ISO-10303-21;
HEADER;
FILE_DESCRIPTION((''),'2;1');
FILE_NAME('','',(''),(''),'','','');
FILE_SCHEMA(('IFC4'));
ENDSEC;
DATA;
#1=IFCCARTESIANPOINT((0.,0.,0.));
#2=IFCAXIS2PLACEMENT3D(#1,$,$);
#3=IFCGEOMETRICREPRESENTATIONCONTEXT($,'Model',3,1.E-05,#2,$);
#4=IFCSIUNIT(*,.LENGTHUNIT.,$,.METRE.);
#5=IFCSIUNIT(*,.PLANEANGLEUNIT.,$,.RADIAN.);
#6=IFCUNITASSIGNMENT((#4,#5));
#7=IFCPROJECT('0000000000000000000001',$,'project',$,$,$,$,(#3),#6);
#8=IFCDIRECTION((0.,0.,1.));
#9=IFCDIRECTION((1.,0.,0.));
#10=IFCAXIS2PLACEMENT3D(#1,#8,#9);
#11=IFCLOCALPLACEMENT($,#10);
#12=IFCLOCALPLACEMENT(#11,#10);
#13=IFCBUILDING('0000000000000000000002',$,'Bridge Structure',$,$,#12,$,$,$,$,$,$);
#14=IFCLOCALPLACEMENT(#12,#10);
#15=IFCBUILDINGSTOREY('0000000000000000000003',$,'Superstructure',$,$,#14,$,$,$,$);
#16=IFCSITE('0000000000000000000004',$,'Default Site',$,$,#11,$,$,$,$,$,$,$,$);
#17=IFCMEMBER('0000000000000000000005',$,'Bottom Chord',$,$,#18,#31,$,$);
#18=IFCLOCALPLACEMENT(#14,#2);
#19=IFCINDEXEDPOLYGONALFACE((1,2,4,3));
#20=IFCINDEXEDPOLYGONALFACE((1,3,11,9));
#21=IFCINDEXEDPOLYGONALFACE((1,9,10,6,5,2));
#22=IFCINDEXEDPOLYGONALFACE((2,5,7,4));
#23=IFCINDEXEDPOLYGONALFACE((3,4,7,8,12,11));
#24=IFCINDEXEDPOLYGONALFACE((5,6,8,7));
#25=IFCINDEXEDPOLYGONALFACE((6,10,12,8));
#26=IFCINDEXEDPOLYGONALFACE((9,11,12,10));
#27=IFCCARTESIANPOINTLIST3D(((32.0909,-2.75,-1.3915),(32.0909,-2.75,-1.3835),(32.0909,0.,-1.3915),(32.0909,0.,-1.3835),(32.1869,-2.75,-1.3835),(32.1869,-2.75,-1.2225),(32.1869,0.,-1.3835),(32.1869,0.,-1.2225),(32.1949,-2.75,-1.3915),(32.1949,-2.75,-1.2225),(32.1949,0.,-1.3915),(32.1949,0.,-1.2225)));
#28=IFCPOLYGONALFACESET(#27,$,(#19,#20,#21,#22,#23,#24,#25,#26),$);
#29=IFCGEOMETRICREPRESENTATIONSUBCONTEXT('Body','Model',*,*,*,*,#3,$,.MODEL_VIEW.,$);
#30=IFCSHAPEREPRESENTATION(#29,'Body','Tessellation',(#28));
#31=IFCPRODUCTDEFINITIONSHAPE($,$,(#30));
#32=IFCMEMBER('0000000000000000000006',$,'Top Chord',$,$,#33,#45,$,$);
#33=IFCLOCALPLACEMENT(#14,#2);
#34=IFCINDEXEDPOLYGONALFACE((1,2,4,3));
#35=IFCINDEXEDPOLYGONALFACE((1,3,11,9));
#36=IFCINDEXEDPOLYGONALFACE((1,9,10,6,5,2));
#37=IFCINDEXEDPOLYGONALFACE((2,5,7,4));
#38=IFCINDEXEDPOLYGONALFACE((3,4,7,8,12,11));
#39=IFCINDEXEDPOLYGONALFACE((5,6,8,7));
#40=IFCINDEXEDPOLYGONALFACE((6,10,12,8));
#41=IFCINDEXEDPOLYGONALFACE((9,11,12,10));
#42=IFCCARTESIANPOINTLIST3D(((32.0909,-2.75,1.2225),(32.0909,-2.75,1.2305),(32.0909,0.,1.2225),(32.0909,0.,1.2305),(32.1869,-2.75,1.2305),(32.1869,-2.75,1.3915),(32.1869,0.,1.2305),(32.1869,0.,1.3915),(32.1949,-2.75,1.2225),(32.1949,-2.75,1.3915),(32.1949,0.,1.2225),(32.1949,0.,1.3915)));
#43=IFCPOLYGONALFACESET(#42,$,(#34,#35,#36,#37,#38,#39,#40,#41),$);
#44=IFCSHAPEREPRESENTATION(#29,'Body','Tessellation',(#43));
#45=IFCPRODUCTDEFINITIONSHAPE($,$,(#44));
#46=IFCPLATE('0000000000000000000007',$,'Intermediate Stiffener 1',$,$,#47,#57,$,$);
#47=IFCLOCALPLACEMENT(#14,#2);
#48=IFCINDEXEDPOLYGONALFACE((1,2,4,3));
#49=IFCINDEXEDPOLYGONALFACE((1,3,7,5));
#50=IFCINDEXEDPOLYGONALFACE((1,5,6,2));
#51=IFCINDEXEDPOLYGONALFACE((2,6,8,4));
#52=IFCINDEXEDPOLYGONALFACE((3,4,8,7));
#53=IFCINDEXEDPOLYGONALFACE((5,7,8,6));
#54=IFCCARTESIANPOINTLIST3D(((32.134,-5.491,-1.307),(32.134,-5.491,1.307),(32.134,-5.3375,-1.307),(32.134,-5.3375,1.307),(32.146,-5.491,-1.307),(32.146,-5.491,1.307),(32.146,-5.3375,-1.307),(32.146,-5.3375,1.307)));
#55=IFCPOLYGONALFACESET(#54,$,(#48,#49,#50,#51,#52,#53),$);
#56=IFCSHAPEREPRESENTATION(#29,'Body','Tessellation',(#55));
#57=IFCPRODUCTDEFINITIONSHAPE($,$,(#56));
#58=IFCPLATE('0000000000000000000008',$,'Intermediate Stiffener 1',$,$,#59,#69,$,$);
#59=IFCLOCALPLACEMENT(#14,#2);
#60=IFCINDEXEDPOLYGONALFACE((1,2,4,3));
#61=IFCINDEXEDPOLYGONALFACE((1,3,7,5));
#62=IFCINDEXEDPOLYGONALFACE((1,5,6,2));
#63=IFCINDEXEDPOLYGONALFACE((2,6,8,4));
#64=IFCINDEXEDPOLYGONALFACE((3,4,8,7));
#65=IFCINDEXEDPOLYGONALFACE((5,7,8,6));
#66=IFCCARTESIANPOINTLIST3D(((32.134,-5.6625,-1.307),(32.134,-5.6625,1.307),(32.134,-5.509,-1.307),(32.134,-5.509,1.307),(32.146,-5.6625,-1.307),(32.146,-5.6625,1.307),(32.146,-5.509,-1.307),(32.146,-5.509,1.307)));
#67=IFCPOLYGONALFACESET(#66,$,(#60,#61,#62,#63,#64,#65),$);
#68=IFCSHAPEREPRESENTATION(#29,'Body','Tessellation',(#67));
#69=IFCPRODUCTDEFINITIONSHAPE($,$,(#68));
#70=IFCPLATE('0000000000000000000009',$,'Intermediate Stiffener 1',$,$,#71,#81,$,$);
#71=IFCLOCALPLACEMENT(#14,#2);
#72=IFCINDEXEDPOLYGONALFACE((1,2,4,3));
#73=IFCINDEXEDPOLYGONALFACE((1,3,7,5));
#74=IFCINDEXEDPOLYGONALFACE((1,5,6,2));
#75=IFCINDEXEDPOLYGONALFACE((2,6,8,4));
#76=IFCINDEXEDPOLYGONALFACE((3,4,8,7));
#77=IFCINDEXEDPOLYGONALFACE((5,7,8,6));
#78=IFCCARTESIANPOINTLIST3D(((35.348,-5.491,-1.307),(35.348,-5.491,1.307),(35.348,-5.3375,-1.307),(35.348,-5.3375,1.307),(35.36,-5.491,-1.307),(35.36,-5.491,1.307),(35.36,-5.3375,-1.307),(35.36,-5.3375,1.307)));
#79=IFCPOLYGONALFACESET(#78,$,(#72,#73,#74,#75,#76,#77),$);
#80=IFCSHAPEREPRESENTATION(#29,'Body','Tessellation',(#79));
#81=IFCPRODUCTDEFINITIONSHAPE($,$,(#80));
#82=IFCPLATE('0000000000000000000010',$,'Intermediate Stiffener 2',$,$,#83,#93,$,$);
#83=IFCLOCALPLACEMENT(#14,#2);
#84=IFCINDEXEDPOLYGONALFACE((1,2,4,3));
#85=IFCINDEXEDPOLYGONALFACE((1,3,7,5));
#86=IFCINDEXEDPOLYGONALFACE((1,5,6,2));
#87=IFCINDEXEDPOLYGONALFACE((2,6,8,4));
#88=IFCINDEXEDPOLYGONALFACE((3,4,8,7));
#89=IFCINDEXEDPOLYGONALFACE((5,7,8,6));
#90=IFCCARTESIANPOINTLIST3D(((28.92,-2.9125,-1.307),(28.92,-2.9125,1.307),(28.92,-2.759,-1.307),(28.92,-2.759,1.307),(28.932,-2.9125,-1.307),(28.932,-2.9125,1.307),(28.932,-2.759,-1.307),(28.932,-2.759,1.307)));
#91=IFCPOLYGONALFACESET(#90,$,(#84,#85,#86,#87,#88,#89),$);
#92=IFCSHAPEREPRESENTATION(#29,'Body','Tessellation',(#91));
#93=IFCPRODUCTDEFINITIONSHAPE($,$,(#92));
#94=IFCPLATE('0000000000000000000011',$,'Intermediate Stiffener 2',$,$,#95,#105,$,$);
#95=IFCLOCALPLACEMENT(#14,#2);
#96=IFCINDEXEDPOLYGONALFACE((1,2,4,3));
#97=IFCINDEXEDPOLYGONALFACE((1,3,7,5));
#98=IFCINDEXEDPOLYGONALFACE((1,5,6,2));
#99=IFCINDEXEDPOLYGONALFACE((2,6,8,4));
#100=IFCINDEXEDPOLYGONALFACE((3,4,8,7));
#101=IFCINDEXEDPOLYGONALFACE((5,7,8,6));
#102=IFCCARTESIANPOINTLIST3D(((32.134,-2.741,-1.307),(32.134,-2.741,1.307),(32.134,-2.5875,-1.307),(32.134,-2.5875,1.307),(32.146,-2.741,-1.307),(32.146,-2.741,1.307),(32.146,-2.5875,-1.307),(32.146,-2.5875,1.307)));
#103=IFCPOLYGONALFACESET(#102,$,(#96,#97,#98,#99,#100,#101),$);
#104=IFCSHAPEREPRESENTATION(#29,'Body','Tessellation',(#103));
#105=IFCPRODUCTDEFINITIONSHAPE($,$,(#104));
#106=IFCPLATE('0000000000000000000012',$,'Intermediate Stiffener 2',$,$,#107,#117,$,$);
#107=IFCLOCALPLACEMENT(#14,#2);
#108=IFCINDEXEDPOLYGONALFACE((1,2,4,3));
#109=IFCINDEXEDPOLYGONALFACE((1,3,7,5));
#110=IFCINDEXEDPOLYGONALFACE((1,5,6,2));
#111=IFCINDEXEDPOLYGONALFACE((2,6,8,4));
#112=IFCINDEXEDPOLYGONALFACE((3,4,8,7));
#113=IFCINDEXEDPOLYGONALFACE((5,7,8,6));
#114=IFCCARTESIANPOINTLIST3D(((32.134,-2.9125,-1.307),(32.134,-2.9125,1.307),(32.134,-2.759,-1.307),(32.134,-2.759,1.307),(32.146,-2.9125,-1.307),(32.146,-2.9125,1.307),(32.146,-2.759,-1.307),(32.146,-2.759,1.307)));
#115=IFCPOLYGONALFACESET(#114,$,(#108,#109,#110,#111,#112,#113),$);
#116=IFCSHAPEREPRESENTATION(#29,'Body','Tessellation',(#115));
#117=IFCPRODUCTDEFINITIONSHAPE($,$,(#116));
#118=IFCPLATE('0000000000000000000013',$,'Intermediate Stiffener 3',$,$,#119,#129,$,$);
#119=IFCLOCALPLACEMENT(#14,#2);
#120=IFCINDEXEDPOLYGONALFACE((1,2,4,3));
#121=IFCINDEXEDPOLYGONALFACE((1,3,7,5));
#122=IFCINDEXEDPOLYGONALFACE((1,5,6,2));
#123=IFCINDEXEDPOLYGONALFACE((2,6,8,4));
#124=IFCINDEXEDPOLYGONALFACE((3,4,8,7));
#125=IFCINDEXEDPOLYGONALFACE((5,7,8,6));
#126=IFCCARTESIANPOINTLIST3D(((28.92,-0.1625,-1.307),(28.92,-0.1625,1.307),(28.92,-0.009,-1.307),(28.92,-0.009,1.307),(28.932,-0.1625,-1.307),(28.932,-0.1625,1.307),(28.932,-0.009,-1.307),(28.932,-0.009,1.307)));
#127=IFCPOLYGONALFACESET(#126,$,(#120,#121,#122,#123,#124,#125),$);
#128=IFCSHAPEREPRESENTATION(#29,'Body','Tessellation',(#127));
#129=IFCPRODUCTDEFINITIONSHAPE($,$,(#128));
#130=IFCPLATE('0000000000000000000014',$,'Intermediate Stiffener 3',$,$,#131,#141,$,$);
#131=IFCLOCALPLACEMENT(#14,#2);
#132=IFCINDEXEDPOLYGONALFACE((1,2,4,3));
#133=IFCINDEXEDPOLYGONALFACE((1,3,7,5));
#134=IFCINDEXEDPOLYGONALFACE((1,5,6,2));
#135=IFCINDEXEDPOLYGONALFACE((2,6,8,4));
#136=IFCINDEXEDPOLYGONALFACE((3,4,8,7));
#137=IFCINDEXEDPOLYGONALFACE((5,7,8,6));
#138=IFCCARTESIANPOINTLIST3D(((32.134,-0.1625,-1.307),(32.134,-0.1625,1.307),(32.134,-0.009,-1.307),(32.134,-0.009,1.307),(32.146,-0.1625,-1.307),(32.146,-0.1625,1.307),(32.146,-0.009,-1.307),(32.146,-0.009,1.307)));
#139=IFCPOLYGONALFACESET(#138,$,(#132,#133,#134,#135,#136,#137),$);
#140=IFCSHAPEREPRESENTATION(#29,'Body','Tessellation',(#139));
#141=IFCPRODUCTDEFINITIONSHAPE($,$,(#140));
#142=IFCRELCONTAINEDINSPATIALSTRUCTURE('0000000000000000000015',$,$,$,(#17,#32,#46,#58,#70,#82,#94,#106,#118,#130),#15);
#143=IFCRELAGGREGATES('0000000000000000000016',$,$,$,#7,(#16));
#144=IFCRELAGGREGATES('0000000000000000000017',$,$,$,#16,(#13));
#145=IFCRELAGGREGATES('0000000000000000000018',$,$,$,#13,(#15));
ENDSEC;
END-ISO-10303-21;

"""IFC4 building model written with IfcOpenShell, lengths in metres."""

from ifc_helpers import new_model, si_unit, frame, origin, origin_with_axes, origin_2d_with_axis, place, context, subcontext, project, spatial, rectangle, l_section, extrude, element, save


model = new_model("IFC4")

# Units and contexts
model_context = context("Model", 3, precision=1e-05, world=origin())
body_context = subcontext(model_context, "Body", "Model", "MODEL_VIEW")
ifc_project = project(units=[si_unit("LENGTHUNIT", "METRE"), si_unit("PLANEANGLEUNIT", "RADIAN")], contexts=[model_context])

# Site, building, storey
site_placement = place(None, origin_with_axes())
site = spatial("IfcSite", under=ifc_project, at=site_placement, Name="Default Site")
building_placement = place(site_placement, origin_with_axes())
building = spatial("IfcBuilding", under=site, at=building_placement, Name="Bridge Structure")
storey_placement = place(building_placement, origin_with_axes())
storey = spatial("IfcBuildingStorey", under=building, at=storey_placement, Name="Superstructure")

# Members
for number, where, z_axis, x_axis, name in (
    (1, (32.1429, -2.75, -1.307), (0.0, 1.0, 0.0), (-1.0, 0.0, 0.0), "Bottom Chord"),
    (2, (32.1429, -2.75, 1.307), (0.0, 1.0, 0.0), (-1.0, 0.0, 0.0), "Top Chord"),
):
    element("IfcMember", number, at=place(storey_placement, frame(where, z_axis=z_axis, x_axis=x_axis)), inside=storey, Name=name, context=body_context, shape_type="SweptSolid", body=[
        extrude(l_section(Depth=0.169, Width=0.104, Thickness=0.008, at=origin_2d_with_axis()), origin_with_axes(), (0.0, 0.0, 1.0), 2.75),
    ])

# Plates
for number, where, z_axis, x_axis, name in (
    (3, (32.14, -5.4143, -1.307), (0.0, 0.0, 1.0), (1.0, 0.0, 0.0), "Intermediate Stiffener 1"),
    (4, (32.14, -5.5857, -1.307), (0.0, 0.0, 1.0), (1.0, 0.0, 0.0), "Intermediate Stiffener 1"),
    (5, (35.354, -5.4143, -1.307), (0.0, 0.0, 1.0), (1.0, 0.0, 0.0), "Intermediate Stiffener 1"),
    (6, (28.926, -2.8357, -1.307), (0.0, 0.0, 1.0), (1.0, 0.0, 0.0), "Intermediate Stiffener 2"),
    (7, (32.14, -2.6643, -1.307), (0.0, 0.0, 1.0), (1.0, 0.0, 0.0), "Intermediate Stiffener 2"),
    (8, (32.14, -2.8357, -1.307), (0.0, 0.0, 1.0), (1.0, 0.0, 0.0), "Intermediate Stiffener 2"),
    (9, (28.926, -0.0858, -1.307), (0.0, 0.0, 1.0), (1.0, 0.0, 0.0), "Intermediate Stiffener 3"),
    (10, (32.14, -0.0858, -1.307), (0.0, 0.0, 1.0), (1.0, 0.0, 0.0), "Intermediate Stiffener 3"),
):
    element("IfcPlate", number, at=place(storey_placement, frame(where, z_axis=z_axis, x_axis=x_axis)), inside=storey, Name=name, context=body_context, shape_type="SweptSolid", body=[
        extrude(rectangle(XDim=0.012, YDim=0.1535, at=origin_2d_with_axis()), origin_with_axes(), (0.0, 0.0, 1.0), 2.614),
    ])

save(model, "model.ifc")
